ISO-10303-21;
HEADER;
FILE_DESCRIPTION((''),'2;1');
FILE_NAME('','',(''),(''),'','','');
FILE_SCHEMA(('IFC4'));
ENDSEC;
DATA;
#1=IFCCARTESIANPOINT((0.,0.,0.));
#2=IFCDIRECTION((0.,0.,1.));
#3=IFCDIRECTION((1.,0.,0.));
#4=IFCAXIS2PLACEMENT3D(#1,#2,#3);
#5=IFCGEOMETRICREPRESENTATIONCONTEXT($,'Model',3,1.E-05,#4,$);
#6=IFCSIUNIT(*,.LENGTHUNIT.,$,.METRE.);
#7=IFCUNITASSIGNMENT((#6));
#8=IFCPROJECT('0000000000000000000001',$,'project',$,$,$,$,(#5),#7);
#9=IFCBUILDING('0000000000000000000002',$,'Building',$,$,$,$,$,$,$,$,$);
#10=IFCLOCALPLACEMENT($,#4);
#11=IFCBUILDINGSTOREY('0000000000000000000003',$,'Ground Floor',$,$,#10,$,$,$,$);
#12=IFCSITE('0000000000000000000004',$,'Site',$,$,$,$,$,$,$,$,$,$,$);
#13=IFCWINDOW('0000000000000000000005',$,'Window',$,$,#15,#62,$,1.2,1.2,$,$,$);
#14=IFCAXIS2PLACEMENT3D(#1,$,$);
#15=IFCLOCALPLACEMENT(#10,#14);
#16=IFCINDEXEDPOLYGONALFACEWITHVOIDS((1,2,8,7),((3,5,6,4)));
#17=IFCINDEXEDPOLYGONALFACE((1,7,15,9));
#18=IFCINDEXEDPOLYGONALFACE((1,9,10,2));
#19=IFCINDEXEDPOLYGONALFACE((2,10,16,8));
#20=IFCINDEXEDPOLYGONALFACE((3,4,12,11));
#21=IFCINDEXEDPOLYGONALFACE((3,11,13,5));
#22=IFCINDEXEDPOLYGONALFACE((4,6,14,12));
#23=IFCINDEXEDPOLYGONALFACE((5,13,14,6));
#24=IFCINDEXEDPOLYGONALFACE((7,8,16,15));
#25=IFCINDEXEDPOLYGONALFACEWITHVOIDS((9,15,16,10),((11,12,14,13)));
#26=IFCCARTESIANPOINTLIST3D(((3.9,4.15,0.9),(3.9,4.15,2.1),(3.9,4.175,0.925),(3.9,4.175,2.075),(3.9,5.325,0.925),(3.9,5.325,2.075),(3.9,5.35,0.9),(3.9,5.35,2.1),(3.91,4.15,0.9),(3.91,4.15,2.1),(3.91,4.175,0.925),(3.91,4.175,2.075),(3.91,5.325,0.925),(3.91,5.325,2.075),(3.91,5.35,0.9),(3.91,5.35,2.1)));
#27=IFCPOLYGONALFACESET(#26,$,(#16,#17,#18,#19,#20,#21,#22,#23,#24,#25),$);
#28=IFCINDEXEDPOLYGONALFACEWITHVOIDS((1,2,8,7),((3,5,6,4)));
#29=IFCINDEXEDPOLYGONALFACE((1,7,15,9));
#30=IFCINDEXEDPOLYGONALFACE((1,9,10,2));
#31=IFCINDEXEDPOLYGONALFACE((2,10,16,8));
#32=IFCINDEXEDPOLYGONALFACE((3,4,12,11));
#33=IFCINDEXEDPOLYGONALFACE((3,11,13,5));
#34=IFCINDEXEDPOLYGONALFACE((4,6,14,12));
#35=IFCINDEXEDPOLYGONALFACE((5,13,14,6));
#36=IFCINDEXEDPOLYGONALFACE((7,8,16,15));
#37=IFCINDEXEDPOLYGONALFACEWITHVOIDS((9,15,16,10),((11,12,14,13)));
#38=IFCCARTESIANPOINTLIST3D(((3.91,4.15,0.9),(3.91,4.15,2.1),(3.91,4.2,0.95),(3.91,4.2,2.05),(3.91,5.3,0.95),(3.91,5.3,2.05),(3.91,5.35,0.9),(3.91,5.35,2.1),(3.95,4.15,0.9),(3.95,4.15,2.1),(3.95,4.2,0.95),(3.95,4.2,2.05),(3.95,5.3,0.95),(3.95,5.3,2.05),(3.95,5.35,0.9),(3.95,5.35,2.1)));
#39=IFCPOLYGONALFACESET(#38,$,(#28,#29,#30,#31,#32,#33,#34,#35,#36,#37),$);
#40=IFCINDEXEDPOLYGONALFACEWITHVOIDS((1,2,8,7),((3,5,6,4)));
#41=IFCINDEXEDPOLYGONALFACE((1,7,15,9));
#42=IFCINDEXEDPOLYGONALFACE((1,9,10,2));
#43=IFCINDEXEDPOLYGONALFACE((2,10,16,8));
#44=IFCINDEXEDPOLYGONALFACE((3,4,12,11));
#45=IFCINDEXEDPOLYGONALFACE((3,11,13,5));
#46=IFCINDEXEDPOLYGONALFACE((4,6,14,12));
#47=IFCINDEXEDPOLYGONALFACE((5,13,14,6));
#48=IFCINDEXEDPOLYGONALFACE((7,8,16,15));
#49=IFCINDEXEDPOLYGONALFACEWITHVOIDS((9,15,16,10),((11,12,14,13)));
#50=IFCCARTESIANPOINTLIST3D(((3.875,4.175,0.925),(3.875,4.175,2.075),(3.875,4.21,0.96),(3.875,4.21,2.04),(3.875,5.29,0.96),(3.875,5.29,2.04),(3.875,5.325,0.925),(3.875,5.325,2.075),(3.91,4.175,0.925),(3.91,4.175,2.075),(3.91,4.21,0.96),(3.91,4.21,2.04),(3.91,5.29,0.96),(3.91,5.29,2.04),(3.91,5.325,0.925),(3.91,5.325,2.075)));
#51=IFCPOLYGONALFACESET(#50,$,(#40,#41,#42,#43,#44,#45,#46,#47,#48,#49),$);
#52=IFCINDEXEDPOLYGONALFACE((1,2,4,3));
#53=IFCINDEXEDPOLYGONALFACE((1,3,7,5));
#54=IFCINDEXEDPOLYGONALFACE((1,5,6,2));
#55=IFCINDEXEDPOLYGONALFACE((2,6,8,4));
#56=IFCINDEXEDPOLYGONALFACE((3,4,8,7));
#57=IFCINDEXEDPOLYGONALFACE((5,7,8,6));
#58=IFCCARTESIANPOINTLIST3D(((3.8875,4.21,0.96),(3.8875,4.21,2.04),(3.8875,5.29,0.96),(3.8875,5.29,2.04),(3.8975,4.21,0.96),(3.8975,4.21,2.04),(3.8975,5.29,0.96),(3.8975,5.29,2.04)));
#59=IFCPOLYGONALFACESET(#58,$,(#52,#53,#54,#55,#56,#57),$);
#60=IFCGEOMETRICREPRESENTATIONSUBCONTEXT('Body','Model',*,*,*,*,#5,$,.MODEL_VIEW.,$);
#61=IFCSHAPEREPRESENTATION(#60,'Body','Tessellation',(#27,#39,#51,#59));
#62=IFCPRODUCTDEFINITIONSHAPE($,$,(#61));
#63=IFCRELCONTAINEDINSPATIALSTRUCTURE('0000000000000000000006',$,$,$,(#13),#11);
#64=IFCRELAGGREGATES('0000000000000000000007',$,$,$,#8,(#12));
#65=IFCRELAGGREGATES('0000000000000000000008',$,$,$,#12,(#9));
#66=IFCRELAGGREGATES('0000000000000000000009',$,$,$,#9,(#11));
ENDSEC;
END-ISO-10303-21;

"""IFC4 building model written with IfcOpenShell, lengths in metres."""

from ifc_helpers import new_model, si_unit, frame, origin_with_axes, place, context, subcontext, project, spatial, line, indexed_curve, outline, extrude, element, save


model = new_model("IFC4")

# Units and contexts
model_context = context("Model", 3, precision=1e-05, world=origin_with_axes())
body_context = subcontext(model_context, "Body", "Model", "MODEL_VIEW")
ifc_project = project(units=[si_unit("LENGTHUNIT", "METRE")], contexts=[model_context])

# Site, building, storey
site = spatial("IfcSite", under=ifc_project, Name="Site")
building = spatial("IfcBuilding", under=site, Name="Building")
storey_placement = place(None, origin_with_axes())
storey = spatial("IfcBuildingStorey", under=building, at=storey_placement, Name="Ground Floor")

# Window
window_1_placement = place(storey_placement, frame((4.0, 4.15, 0.9), z_axis=(0.0, 0.0, 1.0), x_axis=(0.0, 1.0, 0.0)))
element("IfcWindow", 1, at=window_1_placement, inside=storey, Name="Window", OverallHeight=1.2, OverallWidth=1.2, context=body_context, shape_type="SweptSolid", body=[
    extrude(outline(indexed_curve([(0.0, 0.0), (1.2, 0.0), (1.2, 1.2), (0.0, 1.2)], segments=[line(1, 2, 3, 4, 1)]), holes=[indexed_curve([(0.025, 0.025), (1.175, 0.025), (1.175, 1.175), (0.025, 1.175)], segments=[line(1, 2, 3, 4, 1)])]), frame((0.0, 0.09, 0.0), z_axis=(0.0, -1.0, 0.0), x_axis=(1.0, 0.0, 0.0)), (0.0, 0.0, -1.0), 0.01),
    extrude(outline(indexed_curve([(0.0, 0.0), (1.2, 0.0), (1.2, 1.2), (0.0, 1.2)], segments=[line(1, 2, 3, 4, 1)]), holes=[indexed_curve([(0.05, 0.05), (1.15, 0.05), (1.15, 1.15), (0.05, 1.15)], segments=[line(1, 2, 3, 4, 1)])]), frame((0.0, 0.05, 0.0), z_axis=(0.0, -1.0, 0.0), x_axis=(1.0, 0.0, 0.0)), (0.0, 0.0, -1.0), 0.04),
    extrude(outline(indexed_curve([(0.0, 0.0), (1.15, 0.0), (1.15, 1.15), (0.0, 1.15)], segments=[line(1, 2, 3, 4, 1)]), holes=[indexed_curve([(0.035, 0.035), (1.115, 0.035), (1.115, 1.115), (0.035, 1.115)], segments=[line(1, 2, 3, 4, 1)])]), frame((0.025, 0.09, 0.025), z_axis=(0.0, -1.0, 0.0), x_axis=(1.0, 0.0, 0.0)), (0.0, 0.0, -1.0), 0.035),
    extrude(outline(indexed_curve([(0.035, 0.035), (1.115, 0.035), (1.115, 1.115), (0.035, 1.115)], segments=[line(1, 2, 3, 4, 1)])), frame((0.025, 0.1025, 0.025), z_axis=(0.0, -1.0, 0.0), x_axis=(1.0, 0.0, 0.0)), (0.0, 0.0, -1.0), 0.01),
])

save(model, "model.ifc")
